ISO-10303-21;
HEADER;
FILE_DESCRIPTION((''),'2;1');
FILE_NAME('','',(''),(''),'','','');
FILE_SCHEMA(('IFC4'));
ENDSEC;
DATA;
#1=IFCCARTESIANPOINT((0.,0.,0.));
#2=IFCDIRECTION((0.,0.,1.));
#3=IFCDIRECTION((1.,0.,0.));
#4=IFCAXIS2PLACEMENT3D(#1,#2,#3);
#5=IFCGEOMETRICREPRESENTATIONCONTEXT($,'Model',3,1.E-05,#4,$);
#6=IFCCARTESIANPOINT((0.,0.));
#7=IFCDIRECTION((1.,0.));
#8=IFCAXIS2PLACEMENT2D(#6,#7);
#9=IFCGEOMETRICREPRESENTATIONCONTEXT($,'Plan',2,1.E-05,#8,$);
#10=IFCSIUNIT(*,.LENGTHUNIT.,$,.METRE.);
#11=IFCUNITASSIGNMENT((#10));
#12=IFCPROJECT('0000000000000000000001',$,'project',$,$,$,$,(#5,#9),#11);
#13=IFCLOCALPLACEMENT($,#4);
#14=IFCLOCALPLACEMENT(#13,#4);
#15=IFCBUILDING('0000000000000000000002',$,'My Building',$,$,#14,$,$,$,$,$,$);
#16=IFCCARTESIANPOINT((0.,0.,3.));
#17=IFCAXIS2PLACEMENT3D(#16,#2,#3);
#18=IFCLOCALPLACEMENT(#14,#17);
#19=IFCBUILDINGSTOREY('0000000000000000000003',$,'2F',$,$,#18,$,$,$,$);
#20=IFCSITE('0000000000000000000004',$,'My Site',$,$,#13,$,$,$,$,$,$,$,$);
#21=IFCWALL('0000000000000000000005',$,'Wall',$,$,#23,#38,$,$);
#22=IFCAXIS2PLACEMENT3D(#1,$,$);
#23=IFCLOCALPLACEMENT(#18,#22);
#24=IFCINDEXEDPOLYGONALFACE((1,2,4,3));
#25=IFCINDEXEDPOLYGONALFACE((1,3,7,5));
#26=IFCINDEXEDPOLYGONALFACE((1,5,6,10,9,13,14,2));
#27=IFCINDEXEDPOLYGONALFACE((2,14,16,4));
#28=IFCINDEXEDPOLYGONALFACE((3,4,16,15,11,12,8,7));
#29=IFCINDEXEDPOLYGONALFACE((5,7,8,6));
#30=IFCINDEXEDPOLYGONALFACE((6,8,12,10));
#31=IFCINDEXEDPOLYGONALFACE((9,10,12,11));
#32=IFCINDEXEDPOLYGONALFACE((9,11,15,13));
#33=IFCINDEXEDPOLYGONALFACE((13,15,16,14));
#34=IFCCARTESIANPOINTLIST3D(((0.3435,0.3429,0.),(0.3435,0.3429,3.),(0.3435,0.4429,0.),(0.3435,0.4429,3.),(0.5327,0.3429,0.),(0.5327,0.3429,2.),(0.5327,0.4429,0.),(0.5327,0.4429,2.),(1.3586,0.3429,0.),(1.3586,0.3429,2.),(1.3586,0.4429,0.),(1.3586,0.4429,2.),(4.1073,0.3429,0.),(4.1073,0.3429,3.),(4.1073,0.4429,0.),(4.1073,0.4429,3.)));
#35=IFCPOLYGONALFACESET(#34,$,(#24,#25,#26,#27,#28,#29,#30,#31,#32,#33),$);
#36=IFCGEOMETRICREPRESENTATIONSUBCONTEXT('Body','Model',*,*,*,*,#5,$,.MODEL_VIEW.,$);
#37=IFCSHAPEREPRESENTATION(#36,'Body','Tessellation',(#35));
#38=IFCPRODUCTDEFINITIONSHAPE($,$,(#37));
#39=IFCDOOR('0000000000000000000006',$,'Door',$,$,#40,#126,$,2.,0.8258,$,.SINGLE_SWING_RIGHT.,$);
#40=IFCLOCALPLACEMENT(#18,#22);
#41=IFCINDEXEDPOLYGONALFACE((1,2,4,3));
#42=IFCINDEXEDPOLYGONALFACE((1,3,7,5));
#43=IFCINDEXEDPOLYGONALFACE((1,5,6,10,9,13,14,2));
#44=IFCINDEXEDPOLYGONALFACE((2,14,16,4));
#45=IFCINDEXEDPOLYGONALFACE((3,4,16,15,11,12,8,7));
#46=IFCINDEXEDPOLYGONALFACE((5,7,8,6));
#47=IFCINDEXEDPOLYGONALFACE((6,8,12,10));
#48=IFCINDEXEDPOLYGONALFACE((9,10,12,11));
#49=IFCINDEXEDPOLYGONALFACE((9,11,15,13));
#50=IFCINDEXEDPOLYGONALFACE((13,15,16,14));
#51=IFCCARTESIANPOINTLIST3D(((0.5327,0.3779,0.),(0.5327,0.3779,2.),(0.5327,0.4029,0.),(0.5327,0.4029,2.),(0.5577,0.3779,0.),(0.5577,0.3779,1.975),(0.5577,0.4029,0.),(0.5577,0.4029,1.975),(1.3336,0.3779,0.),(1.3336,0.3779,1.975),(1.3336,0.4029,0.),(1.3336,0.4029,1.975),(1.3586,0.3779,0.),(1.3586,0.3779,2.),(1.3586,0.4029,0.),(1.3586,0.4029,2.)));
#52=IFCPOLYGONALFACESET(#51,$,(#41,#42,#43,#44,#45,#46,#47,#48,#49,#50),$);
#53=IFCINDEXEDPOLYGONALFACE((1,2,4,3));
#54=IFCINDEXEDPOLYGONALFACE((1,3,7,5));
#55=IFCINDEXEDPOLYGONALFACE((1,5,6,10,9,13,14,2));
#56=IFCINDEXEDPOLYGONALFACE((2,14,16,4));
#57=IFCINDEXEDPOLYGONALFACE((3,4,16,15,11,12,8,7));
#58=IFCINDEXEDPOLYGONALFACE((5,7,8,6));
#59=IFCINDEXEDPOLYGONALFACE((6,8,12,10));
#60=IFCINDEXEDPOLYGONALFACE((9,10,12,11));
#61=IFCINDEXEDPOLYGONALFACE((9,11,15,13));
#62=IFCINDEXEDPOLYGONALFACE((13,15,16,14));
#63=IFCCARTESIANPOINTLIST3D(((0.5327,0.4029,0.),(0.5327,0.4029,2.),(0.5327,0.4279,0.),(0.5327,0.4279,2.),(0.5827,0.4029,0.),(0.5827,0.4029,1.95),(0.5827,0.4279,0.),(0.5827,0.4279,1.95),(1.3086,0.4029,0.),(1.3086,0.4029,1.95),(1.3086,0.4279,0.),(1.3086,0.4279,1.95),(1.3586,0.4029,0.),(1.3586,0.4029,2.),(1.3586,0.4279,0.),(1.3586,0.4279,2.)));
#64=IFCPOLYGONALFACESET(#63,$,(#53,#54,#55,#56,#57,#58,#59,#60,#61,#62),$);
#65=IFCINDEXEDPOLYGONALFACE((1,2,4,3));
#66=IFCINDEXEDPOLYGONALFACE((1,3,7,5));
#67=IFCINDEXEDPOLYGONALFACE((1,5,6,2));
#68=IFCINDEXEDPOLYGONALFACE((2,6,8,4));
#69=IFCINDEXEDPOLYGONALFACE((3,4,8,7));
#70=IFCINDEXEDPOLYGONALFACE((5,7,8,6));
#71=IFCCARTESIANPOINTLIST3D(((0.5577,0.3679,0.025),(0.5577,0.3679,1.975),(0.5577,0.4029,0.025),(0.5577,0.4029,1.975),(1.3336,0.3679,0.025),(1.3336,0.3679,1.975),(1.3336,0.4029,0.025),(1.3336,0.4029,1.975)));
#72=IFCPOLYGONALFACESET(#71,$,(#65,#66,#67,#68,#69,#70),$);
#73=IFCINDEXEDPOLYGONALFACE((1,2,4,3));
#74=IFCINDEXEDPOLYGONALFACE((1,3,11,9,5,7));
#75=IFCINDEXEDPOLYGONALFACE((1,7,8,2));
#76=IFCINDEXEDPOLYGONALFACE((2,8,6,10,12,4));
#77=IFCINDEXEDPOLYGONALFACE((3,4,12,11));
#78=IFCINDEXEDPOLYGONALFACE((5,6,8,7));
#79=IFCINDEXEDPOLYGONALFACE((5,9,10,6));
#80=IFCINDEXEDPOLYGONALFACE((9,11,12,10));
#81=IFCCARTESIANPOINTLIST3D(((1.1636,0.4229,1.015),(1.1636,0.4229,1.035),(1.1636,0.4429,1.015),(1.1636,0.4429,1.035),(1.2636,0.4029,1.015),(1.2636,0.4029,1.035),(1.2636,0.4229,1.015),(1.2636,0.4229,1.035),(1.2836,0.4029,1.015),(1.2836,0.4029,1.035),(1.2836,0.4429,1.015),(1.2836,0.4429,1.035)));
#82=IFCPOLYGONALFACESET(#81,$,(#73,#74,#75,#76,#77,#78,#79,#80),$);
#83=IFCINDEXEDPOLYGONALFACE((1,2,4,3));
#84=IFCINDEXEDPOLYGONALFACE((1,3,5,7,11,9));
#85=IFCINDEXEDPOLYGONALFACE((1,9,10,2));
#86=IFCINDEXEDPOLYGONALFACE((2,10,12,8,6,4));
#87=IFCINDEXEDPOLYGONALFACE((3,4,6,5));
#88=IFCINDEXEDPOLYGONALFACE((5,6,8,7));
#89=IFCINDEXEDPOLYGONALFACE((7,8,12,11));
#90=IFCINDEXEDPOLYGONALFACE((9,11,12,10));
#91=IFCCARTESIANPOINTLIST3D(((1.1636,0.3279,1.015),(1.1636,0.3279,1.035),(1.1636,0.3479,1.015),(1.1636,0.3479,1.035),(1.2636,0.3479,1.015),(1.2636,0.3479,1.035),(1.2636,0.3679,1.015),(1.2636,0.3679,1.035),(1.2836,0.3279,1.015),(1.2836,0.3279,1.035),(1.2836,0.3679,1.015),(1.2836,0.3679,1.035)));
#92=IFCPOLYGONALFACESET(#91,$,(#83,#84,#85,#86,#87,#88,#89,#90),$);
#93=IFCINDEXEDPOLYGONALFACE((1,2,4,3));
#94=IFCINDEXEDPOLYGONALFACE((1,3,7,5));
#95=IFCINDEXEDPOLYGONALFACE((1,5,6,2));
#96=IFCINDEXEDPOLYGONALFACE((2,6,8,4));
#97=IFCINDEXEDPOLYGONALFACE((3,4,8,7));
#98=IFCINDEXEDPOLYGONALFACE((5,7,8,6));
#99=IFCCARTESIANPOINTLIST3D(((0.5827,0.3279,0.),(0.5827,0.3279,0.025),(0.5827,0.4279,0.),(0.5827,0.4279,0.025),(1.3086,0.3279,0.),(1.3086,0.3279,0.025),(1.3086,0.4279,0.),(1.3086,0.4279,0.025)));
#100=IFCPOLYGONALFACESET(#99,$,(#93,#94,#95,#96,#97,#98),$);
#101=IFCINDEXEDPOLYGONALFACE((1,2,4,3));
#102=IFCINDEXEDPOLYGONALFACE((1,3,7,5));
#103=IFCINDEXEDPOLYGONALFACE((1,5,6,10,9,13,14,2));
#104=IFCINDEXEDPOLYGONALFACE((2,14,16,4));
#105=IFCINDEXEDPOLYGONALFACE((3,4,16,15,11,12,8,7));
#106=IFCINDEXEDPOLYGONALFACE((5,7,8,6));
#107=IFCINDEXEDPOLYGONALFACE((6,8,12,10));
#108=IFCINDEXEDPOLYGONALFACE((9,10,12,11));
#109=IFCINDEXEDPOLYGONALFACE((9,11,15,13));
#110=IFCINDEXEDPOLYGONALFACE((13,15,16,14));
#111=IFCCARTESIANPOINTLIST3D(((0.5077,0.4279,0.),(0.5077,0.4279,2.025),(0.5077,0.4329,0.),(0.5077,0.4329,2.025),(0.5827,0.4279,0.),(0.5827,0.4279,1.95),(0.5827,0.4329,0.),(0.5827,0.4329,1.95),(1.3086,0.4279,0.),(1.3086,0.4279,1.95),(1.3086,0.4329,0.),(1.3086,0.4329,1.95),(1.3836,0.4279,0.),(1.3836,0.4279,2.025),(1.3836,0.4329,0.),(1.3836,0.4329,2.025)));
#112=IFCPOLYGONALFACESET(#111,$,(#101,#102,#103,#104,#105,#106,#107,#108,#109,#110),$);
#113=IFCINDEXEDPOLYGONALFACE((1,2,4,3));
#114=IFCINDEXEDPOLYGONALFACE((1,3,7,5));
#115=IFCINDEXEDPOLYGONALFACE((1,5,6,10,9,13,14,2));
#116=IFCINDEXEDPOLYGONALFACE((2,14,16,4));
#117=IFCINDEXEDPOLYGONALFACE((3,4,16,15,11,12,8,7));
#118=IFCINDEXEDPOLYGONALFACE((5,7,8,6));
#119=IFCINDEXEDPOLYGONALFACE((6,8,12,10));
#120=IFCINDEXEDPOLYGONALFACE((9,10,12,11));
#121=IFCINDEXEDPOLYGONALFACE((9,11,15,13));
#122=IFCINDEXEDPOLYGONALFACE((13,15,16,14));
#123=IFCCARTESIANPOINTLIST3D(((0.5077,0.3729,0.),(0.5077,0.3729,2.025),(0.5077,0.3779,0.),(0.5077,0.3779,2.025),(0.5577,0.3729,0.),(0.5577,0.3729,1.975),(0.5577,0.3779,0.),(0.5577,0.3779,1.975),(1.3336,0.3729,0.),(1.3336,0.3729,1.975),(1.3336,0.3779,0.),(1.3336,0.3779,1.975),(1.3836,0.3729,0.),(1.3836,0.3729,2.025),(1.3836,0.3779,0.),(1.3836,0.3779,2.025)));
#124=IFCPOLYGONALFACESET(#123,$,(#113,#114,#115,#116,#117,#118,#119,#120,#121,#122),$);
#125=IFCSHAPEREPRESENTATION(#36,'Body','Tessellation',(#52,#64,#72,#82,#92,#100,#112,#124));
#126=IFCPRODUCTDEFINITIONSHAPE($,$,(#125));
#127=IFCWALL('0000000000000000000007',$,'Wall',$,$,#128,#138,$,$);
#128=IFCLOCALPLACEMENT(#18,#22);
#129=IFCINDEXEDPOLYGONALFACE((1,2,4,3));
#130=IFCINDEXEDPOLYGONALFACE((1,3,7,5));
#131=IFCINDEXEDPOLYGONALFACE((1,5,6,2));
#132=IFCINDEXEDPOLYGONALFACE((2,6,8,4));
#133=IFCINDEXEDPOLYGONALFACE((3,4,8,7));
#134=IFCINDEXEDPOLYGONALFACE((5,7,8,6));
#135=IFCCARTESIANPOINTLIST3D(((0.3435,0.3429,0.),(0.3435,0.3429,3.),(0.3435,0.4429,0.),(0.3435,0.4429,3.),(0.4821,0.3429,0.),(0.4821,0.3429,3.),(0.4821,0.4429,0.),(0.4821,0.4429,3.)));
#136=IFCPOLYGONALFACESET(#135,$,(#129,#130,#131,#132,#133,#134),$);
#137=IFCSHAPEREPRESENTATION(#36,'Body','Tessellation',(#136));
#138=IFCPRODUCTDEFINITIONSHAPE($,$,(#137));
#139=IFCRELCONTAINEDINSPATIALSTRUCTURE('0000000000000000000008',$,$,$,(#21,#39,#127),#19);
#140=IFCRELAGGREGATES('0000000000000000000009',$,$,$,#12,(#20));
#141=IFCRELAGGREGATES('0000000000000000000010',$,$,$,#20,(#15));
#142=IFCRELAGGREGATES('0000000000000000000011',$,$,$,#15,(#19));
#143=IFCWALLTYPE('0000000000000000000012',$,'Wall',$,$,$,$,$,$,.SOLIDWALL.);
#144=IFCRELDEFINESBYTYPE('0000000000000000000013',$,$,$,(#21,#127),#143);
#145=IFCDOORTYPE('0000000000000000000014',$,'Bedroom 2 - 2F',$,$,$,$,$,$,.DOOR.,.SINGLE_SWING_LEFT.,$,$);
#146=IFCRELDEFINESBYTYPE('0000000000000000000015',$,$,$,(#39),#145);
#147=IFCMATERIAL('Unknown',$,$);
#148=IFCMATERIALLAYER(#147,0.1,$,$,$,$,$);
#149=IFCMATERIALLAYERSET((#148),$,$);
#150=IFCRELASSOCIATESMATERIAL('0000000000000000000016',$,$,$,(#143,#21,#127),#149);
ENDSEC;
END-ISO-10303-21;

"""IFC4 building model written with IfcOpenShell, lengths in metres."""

from ifc_helpers import new_model, entity, si_unit, frame, origin_with_axes, origin_2d_with_axis, place, context, subcontext, project, spatial, line, indexed_curve, outline, extrude, shape, source, transform, mapped, material, layer, layer_set, layer_usage, type_object, type_shapes, element, fill, save


model = new_model("IFC4")

# Units and contexts
model_context = context("Model", 3, precision=1e-05, world=origin_with_axes())
plan_context = context("Plan", 2, precision=1e-05, world=origin_2d_with_axis())
body_context_1 = subcontext(model_context, "Body", "Model", "MODEL_VIEW")
body_context_2 = subcontext(plan_context, "Body", "Plan", "PLAN_VIEW")
ifc_project = project(units=[si_unit("LENGTHUNIT", "METRE")], contexts=[model_context, plan_context])

# Site, building, storey
site_placement = place(None, origin_with_axes())
site = spatial("IfcSite", under=ifc_project, at=site_placement, Name="My Site")
building_placement = place(site_placement, origin_with_axes())
building = spatial("IfcBuilding", under=site, at=building_placement, Name="My Building")
storey_placement = place(building_placement, frame((0.0, 0.0, 3.0), z_axis=(0.0, 0.0, 1.0), x_axis=(1.0, 0.0, 0.0)))
storey = spatial("IfcBuildingStorey", under=building, at=storey_placement, Name="2F")

# Shared definitions
ifc_material = material(Name="Unknown")

# Shared definitions
ifc_layer = layer(ifc_material, 0.1)
ifc_layer_set = layer_set([ifc_layer])
wall_type = type_object("IfcWallType", Name="Wall", PredefinedType="SOLIDWALL", material=ifc_layer_set)

# Wall, opening, door
ifc_layer_usage_1 = layer_usage(ifc_layer_set, "AXIS2", "POSITIVE", 0.0)
wall_1_placement = place(storey_placement, frame((4.2073, 0.4429, 0.0), z_axis=(0.0, 0.0, 1.0), x_axis=(-1.0, 0.0, 0.0)))
wall_1 = element("IfcWall", 1, at=wall_1_placement, inside=storey, type_object=wall_type, material=ifc_layer_usage_1, Name="Wall", context=body_context_1, shape_type="SweptSolid", body=[
    extrude(outline(indexed_curve([(0.1, 0.0), (0.1, 0.1), (3.8638, 0.1), (3.8638, 0.0)], segments=[line(1, 2, 3, 4, 1)])), origin_with_axes(), (0.0, 0.0, 1.0), 3.0),
])
shared_shape_1 = source(origin_with_axes(), body_context_1, "Body", "SweptSolid", [
    extrude(outline(indexed_curve([(0.0, 0.0), (0.8258, 0.0), (0.8258, 2.0), (0.0, 2.0)], segments=[line(1, 2, 3, 4, 1)])), frame((0.0, -0.6, 0.0), z_axis=(0.0, -1.0, 0.0), x_axis=(1.0, 0.0, 0.0)), (0.0, 0.0, -1.0), 1.2),
])
opening_1_placement = place(wall_1_placement, frame((2.8487, 0.015, 0.0), z_axis=(0.0, 0.0, 1.0), x_axis=(1.0, -0.000001, 0.0)))
opening_1 = element("IfcOpeningElement", 2, at=opening_1_placement, cuts=wall_1, PredefinedType="OPENING", context=body_context_1, shape_type="MappedRepresentation", body=[
    mapped(shared_shape_1, transform((0.0, 0.0, 0.0), x_axis=(1.0, 0.0, 0.0), y_axis=(0.0, 1.0, 0.0), z_axis=(0.0, 0.0, 1.0), scale=1.0)),
])
door_type_1 = type_object("IfcDoorType", Name="Bedroom 2 - 2F", OperationType="SINGLE_SWING_LEFT", PredefinedType="DOOR")
shared_shape_2 = source(origin_with_axes(), body_context_1, "Body", "SweptSolid", [
    extrude(outline(indexed_curve([(0.0, 0.0), (0.0, 2.0), (0.8258, 2.0), (0.8258, 0.0), (0.8008, 0.0), (0.8008, 1.975), (0.025, 1.975), (0.025, 0.0)], segments=[line(1, 2, 3, 4, 5, 6, 7, 8, 1)])), frame((0.0, 0.025, 0.0), z_axis=(0.0, -1.0, 0.0), x_axis=(1.0, 0.0, 0.0)), (0.0, 0.0, -1.0), 0.025),
    extrude(outline(indexed_curve([(0.0, 0.0), (0.0, 2.0), (0.8258, 2.0), (0.8258, 0.0), (0.7758, 0.0), (0.7758, 1.95), (0.05, 1.95), (0.05, 0.0)], segments=[line(1, 2, 3, 4, 5, 6, 7, 8, 1)])), frame((0.0, 0.0, 0.0), z_axis=(0.0, -1.0, 0.0), x_axis=(1.0, 0.0, 0.0)), (0.0, 0.0, -1.0), 0.025),
    extrude(outline(indexed_curve([(0.0, 0.0), (0.7758, 0.0), (0.7758, 0.035), (0.0, 0.035)], segments=[line(1, 2, 3, 4, 1)])), frame((0.025, 0.025, 0.025), z_axis=(0.0, 0.0, 1.0), x_axis=(1.0, 0.0, 0.0)), (0.0, 0.0, 1.0), 1.95),
    extrude(outline(indexed_curve([(0.0, 0.0), (0.0, -0.04), (0.12, -0.04), (0.12, -0.02), (0.02, -0.02), (0.02, 0.0)], segments=[line(1, 2, 3, 4, 5, 6, 1)])), frame((0.075, 0.025, 1.015), z_axis=(0.0, 0.0, 1.0), x_axis=(1.0, 0.0, 0.0)), (0.0, 0.0, 1.0), 0.02),
    extrude(outline(indexed_curve([(0.0, 0.0), (0.0, 0.04), (0.12, 0.04), (0.12, 0.02), (0.02, 0.02), (0.02, 0.0)], segments=[line(1, 2, 3, 4, 5, 6, 1)])), frame((0.075, 0.06, 1.015), z_axis=(0.0, 0.0, 1.0), x_axis=(1.0, 0.0, 0.0)), (0.0, 0.0, 1.0), 0.02),
    extrude(outline(indexed_curve([(0.0, 0.0), (0.7258, 0.0), (0.7258, 0.1), (0.0, 0.1)], segments=[line(1, 2, 3, 4, 1)])), frame((0.05, 0.0, 0.0), z_axis=(0.0, 0.0, 1.0), x_axis=(1.0, 0.0, 0.0)), (0.0, 0.0, 1.0), 0.025),
    extrude(outline(indexed_curve([(0.0, 0.0), (0.0, 2.025), (0.8758, 2.025), (0.8758, 0.0), (0.8008, 0.0), (0.8008, 1.95), (0.075, 1.95), (0.075, 0.0)], segments=[line(1, 2, 3, 4, 5, 6, 7, 8, 1)])), frame((-0.025, -0.005, 0.0), z_axis=(0.0, -1.0, 0.0), x_axis=(1.0, 0.0, 0.0)), (0.0, 0.0, -1.0), 0.005),
    extrude(outline(indexed_curve([(0.0, 0.0), (0.0, 2.025), (0.8758, 2.025), (0.8758, 0.0), (0.8258, 0.0), (0.8258, 1.975), (0.05, 1.975), (0.05, 0.0)], segments=[line(1, 2, 3, 4, 5, 6, 7, 8, 1)])), frame((-0.025, 0.05, 0.0), z_axis=(0.0, -1.0, 0.0), x_axis=(1.0, 0.0, 0.0)), (0.0, 0.0, -1.0), 0.005),
])
shared_shape_3 = source(origin_with_axes(), body_context_2, "Body", "Curve2D", [
    entity("IfcIndexedPolyCurve", entity("IfcCartesianPointList2D", [[0.0, 0.0], [0.0, 0.05], [0.025, 0.05], [0.025, 0.025], [0.05, 0.025], [0.05, 0.0]]), [entity("IfcLineIndex", [1, 2, 3, 4, 5, 6, 1])]),
    entity("IfcIndexedPolyCurve", entity("IfcCartesianPointList2D", [[0.8258, 0.0], [0.8258, 0.05], [0.8008, 0.05], [0.8008, 0.025], [0.7758, 0.025], [0.7758, 0.0]]), [entity("IfcLineIndex", [1, 2, 3, 4, 5, 6, 1])]),
    entity("IfcTrimmedCurve", entity("IfcEllipse", entity("IfcAxis2Placement2D", entity("IfcCartesianPoint", [0.7658, 0.05]), entity("IfcDirection", [1.0, 0.0])), 0.7408, 0.7758), [entity("IfcCartesianPoint", [0.7658, 0.8258])], [entity("IfcCartesianPoint", [0.025, 0.05])], True, "CARTESIAN"),
    entity("IfcIndexedPolyCurve", entity("IfcCartesianPointList2D", [[0.8008, 0.05], [0.7658, 0.05], [0.7658, 0.8258], [0.8008, 0.8258]]), [entity("IfcLineIndex", [1, 2, 3, 4, 1])]),
])
type_shapes(door_type_1, [shared_shape_2, shared_shape_3])
door_1_placement = place(opening_1_placement, frame((0.0, 0.0, 0.0), z_axis=(0.0, 0.0, 1.0), x_axis=(1.0, 0.0, 0.0)))
door_1 = element("IfcDoor", 3, at=door_1_placement, inside=storey, type_object=door_type_1, Name="Door", OperationType="SINGLE_SWING_RIGHT", OverallHeight=2.0, OverallWidth=0.8258, shapes=[
    shape(body_context_1, "Body", "MappedRepresentation", [mapped(shared_shape_2, transform((0.0, 0.0, 0.0), x_axis=(1.0, 0.0, 0.0), y_axis=(0.0, 1.0, 0.0), z_axis=(0.0, 0.0, 1.0), scale=1.0))]),
    shape(body_context_2, "Body", "MappedRepresentation", [mapped(shared_shape_3, transform((0.0, 0.0, 0.0), x_axis=(1.0, 0.0, 0.0), y_axis=(0.0, 1.0, 0.0), z_axis=(0.0, 0.0, 1.0), scale=1.0))]),
])
fill(opening_1, door_1)

# Wall
ifc_layer_usage_2 = layer_usage(ifc_layer_set, "AXIS2", "POSITIVE", 0.0)
wall_2_placement = place(storey_placement, frame((0.4821, 0.4429, 0.0), z_axis=(0.0, 0.0, 1.0), x_axis=(-1.0, 0.0, 0.0)))
element("IfcWall", 4, at=wall_2_placement, inside=storey, type_object=wall_type, material=ifc_layer_usage_2, Name="Wall", context=body_context_1, shape_type="SweptSolid", body=[
    extrude(outline(indexed_curve([(0.0, 0.0), (0.0, 0.1), (0.1387, 0.1), (0.1387, 0.0)], segments=[line(1, 2, 3, 4, 1)])), origin_with_axes(), (0.0, 0.0, 1.0), 3.0),
])

save(model, "model.ifc")
